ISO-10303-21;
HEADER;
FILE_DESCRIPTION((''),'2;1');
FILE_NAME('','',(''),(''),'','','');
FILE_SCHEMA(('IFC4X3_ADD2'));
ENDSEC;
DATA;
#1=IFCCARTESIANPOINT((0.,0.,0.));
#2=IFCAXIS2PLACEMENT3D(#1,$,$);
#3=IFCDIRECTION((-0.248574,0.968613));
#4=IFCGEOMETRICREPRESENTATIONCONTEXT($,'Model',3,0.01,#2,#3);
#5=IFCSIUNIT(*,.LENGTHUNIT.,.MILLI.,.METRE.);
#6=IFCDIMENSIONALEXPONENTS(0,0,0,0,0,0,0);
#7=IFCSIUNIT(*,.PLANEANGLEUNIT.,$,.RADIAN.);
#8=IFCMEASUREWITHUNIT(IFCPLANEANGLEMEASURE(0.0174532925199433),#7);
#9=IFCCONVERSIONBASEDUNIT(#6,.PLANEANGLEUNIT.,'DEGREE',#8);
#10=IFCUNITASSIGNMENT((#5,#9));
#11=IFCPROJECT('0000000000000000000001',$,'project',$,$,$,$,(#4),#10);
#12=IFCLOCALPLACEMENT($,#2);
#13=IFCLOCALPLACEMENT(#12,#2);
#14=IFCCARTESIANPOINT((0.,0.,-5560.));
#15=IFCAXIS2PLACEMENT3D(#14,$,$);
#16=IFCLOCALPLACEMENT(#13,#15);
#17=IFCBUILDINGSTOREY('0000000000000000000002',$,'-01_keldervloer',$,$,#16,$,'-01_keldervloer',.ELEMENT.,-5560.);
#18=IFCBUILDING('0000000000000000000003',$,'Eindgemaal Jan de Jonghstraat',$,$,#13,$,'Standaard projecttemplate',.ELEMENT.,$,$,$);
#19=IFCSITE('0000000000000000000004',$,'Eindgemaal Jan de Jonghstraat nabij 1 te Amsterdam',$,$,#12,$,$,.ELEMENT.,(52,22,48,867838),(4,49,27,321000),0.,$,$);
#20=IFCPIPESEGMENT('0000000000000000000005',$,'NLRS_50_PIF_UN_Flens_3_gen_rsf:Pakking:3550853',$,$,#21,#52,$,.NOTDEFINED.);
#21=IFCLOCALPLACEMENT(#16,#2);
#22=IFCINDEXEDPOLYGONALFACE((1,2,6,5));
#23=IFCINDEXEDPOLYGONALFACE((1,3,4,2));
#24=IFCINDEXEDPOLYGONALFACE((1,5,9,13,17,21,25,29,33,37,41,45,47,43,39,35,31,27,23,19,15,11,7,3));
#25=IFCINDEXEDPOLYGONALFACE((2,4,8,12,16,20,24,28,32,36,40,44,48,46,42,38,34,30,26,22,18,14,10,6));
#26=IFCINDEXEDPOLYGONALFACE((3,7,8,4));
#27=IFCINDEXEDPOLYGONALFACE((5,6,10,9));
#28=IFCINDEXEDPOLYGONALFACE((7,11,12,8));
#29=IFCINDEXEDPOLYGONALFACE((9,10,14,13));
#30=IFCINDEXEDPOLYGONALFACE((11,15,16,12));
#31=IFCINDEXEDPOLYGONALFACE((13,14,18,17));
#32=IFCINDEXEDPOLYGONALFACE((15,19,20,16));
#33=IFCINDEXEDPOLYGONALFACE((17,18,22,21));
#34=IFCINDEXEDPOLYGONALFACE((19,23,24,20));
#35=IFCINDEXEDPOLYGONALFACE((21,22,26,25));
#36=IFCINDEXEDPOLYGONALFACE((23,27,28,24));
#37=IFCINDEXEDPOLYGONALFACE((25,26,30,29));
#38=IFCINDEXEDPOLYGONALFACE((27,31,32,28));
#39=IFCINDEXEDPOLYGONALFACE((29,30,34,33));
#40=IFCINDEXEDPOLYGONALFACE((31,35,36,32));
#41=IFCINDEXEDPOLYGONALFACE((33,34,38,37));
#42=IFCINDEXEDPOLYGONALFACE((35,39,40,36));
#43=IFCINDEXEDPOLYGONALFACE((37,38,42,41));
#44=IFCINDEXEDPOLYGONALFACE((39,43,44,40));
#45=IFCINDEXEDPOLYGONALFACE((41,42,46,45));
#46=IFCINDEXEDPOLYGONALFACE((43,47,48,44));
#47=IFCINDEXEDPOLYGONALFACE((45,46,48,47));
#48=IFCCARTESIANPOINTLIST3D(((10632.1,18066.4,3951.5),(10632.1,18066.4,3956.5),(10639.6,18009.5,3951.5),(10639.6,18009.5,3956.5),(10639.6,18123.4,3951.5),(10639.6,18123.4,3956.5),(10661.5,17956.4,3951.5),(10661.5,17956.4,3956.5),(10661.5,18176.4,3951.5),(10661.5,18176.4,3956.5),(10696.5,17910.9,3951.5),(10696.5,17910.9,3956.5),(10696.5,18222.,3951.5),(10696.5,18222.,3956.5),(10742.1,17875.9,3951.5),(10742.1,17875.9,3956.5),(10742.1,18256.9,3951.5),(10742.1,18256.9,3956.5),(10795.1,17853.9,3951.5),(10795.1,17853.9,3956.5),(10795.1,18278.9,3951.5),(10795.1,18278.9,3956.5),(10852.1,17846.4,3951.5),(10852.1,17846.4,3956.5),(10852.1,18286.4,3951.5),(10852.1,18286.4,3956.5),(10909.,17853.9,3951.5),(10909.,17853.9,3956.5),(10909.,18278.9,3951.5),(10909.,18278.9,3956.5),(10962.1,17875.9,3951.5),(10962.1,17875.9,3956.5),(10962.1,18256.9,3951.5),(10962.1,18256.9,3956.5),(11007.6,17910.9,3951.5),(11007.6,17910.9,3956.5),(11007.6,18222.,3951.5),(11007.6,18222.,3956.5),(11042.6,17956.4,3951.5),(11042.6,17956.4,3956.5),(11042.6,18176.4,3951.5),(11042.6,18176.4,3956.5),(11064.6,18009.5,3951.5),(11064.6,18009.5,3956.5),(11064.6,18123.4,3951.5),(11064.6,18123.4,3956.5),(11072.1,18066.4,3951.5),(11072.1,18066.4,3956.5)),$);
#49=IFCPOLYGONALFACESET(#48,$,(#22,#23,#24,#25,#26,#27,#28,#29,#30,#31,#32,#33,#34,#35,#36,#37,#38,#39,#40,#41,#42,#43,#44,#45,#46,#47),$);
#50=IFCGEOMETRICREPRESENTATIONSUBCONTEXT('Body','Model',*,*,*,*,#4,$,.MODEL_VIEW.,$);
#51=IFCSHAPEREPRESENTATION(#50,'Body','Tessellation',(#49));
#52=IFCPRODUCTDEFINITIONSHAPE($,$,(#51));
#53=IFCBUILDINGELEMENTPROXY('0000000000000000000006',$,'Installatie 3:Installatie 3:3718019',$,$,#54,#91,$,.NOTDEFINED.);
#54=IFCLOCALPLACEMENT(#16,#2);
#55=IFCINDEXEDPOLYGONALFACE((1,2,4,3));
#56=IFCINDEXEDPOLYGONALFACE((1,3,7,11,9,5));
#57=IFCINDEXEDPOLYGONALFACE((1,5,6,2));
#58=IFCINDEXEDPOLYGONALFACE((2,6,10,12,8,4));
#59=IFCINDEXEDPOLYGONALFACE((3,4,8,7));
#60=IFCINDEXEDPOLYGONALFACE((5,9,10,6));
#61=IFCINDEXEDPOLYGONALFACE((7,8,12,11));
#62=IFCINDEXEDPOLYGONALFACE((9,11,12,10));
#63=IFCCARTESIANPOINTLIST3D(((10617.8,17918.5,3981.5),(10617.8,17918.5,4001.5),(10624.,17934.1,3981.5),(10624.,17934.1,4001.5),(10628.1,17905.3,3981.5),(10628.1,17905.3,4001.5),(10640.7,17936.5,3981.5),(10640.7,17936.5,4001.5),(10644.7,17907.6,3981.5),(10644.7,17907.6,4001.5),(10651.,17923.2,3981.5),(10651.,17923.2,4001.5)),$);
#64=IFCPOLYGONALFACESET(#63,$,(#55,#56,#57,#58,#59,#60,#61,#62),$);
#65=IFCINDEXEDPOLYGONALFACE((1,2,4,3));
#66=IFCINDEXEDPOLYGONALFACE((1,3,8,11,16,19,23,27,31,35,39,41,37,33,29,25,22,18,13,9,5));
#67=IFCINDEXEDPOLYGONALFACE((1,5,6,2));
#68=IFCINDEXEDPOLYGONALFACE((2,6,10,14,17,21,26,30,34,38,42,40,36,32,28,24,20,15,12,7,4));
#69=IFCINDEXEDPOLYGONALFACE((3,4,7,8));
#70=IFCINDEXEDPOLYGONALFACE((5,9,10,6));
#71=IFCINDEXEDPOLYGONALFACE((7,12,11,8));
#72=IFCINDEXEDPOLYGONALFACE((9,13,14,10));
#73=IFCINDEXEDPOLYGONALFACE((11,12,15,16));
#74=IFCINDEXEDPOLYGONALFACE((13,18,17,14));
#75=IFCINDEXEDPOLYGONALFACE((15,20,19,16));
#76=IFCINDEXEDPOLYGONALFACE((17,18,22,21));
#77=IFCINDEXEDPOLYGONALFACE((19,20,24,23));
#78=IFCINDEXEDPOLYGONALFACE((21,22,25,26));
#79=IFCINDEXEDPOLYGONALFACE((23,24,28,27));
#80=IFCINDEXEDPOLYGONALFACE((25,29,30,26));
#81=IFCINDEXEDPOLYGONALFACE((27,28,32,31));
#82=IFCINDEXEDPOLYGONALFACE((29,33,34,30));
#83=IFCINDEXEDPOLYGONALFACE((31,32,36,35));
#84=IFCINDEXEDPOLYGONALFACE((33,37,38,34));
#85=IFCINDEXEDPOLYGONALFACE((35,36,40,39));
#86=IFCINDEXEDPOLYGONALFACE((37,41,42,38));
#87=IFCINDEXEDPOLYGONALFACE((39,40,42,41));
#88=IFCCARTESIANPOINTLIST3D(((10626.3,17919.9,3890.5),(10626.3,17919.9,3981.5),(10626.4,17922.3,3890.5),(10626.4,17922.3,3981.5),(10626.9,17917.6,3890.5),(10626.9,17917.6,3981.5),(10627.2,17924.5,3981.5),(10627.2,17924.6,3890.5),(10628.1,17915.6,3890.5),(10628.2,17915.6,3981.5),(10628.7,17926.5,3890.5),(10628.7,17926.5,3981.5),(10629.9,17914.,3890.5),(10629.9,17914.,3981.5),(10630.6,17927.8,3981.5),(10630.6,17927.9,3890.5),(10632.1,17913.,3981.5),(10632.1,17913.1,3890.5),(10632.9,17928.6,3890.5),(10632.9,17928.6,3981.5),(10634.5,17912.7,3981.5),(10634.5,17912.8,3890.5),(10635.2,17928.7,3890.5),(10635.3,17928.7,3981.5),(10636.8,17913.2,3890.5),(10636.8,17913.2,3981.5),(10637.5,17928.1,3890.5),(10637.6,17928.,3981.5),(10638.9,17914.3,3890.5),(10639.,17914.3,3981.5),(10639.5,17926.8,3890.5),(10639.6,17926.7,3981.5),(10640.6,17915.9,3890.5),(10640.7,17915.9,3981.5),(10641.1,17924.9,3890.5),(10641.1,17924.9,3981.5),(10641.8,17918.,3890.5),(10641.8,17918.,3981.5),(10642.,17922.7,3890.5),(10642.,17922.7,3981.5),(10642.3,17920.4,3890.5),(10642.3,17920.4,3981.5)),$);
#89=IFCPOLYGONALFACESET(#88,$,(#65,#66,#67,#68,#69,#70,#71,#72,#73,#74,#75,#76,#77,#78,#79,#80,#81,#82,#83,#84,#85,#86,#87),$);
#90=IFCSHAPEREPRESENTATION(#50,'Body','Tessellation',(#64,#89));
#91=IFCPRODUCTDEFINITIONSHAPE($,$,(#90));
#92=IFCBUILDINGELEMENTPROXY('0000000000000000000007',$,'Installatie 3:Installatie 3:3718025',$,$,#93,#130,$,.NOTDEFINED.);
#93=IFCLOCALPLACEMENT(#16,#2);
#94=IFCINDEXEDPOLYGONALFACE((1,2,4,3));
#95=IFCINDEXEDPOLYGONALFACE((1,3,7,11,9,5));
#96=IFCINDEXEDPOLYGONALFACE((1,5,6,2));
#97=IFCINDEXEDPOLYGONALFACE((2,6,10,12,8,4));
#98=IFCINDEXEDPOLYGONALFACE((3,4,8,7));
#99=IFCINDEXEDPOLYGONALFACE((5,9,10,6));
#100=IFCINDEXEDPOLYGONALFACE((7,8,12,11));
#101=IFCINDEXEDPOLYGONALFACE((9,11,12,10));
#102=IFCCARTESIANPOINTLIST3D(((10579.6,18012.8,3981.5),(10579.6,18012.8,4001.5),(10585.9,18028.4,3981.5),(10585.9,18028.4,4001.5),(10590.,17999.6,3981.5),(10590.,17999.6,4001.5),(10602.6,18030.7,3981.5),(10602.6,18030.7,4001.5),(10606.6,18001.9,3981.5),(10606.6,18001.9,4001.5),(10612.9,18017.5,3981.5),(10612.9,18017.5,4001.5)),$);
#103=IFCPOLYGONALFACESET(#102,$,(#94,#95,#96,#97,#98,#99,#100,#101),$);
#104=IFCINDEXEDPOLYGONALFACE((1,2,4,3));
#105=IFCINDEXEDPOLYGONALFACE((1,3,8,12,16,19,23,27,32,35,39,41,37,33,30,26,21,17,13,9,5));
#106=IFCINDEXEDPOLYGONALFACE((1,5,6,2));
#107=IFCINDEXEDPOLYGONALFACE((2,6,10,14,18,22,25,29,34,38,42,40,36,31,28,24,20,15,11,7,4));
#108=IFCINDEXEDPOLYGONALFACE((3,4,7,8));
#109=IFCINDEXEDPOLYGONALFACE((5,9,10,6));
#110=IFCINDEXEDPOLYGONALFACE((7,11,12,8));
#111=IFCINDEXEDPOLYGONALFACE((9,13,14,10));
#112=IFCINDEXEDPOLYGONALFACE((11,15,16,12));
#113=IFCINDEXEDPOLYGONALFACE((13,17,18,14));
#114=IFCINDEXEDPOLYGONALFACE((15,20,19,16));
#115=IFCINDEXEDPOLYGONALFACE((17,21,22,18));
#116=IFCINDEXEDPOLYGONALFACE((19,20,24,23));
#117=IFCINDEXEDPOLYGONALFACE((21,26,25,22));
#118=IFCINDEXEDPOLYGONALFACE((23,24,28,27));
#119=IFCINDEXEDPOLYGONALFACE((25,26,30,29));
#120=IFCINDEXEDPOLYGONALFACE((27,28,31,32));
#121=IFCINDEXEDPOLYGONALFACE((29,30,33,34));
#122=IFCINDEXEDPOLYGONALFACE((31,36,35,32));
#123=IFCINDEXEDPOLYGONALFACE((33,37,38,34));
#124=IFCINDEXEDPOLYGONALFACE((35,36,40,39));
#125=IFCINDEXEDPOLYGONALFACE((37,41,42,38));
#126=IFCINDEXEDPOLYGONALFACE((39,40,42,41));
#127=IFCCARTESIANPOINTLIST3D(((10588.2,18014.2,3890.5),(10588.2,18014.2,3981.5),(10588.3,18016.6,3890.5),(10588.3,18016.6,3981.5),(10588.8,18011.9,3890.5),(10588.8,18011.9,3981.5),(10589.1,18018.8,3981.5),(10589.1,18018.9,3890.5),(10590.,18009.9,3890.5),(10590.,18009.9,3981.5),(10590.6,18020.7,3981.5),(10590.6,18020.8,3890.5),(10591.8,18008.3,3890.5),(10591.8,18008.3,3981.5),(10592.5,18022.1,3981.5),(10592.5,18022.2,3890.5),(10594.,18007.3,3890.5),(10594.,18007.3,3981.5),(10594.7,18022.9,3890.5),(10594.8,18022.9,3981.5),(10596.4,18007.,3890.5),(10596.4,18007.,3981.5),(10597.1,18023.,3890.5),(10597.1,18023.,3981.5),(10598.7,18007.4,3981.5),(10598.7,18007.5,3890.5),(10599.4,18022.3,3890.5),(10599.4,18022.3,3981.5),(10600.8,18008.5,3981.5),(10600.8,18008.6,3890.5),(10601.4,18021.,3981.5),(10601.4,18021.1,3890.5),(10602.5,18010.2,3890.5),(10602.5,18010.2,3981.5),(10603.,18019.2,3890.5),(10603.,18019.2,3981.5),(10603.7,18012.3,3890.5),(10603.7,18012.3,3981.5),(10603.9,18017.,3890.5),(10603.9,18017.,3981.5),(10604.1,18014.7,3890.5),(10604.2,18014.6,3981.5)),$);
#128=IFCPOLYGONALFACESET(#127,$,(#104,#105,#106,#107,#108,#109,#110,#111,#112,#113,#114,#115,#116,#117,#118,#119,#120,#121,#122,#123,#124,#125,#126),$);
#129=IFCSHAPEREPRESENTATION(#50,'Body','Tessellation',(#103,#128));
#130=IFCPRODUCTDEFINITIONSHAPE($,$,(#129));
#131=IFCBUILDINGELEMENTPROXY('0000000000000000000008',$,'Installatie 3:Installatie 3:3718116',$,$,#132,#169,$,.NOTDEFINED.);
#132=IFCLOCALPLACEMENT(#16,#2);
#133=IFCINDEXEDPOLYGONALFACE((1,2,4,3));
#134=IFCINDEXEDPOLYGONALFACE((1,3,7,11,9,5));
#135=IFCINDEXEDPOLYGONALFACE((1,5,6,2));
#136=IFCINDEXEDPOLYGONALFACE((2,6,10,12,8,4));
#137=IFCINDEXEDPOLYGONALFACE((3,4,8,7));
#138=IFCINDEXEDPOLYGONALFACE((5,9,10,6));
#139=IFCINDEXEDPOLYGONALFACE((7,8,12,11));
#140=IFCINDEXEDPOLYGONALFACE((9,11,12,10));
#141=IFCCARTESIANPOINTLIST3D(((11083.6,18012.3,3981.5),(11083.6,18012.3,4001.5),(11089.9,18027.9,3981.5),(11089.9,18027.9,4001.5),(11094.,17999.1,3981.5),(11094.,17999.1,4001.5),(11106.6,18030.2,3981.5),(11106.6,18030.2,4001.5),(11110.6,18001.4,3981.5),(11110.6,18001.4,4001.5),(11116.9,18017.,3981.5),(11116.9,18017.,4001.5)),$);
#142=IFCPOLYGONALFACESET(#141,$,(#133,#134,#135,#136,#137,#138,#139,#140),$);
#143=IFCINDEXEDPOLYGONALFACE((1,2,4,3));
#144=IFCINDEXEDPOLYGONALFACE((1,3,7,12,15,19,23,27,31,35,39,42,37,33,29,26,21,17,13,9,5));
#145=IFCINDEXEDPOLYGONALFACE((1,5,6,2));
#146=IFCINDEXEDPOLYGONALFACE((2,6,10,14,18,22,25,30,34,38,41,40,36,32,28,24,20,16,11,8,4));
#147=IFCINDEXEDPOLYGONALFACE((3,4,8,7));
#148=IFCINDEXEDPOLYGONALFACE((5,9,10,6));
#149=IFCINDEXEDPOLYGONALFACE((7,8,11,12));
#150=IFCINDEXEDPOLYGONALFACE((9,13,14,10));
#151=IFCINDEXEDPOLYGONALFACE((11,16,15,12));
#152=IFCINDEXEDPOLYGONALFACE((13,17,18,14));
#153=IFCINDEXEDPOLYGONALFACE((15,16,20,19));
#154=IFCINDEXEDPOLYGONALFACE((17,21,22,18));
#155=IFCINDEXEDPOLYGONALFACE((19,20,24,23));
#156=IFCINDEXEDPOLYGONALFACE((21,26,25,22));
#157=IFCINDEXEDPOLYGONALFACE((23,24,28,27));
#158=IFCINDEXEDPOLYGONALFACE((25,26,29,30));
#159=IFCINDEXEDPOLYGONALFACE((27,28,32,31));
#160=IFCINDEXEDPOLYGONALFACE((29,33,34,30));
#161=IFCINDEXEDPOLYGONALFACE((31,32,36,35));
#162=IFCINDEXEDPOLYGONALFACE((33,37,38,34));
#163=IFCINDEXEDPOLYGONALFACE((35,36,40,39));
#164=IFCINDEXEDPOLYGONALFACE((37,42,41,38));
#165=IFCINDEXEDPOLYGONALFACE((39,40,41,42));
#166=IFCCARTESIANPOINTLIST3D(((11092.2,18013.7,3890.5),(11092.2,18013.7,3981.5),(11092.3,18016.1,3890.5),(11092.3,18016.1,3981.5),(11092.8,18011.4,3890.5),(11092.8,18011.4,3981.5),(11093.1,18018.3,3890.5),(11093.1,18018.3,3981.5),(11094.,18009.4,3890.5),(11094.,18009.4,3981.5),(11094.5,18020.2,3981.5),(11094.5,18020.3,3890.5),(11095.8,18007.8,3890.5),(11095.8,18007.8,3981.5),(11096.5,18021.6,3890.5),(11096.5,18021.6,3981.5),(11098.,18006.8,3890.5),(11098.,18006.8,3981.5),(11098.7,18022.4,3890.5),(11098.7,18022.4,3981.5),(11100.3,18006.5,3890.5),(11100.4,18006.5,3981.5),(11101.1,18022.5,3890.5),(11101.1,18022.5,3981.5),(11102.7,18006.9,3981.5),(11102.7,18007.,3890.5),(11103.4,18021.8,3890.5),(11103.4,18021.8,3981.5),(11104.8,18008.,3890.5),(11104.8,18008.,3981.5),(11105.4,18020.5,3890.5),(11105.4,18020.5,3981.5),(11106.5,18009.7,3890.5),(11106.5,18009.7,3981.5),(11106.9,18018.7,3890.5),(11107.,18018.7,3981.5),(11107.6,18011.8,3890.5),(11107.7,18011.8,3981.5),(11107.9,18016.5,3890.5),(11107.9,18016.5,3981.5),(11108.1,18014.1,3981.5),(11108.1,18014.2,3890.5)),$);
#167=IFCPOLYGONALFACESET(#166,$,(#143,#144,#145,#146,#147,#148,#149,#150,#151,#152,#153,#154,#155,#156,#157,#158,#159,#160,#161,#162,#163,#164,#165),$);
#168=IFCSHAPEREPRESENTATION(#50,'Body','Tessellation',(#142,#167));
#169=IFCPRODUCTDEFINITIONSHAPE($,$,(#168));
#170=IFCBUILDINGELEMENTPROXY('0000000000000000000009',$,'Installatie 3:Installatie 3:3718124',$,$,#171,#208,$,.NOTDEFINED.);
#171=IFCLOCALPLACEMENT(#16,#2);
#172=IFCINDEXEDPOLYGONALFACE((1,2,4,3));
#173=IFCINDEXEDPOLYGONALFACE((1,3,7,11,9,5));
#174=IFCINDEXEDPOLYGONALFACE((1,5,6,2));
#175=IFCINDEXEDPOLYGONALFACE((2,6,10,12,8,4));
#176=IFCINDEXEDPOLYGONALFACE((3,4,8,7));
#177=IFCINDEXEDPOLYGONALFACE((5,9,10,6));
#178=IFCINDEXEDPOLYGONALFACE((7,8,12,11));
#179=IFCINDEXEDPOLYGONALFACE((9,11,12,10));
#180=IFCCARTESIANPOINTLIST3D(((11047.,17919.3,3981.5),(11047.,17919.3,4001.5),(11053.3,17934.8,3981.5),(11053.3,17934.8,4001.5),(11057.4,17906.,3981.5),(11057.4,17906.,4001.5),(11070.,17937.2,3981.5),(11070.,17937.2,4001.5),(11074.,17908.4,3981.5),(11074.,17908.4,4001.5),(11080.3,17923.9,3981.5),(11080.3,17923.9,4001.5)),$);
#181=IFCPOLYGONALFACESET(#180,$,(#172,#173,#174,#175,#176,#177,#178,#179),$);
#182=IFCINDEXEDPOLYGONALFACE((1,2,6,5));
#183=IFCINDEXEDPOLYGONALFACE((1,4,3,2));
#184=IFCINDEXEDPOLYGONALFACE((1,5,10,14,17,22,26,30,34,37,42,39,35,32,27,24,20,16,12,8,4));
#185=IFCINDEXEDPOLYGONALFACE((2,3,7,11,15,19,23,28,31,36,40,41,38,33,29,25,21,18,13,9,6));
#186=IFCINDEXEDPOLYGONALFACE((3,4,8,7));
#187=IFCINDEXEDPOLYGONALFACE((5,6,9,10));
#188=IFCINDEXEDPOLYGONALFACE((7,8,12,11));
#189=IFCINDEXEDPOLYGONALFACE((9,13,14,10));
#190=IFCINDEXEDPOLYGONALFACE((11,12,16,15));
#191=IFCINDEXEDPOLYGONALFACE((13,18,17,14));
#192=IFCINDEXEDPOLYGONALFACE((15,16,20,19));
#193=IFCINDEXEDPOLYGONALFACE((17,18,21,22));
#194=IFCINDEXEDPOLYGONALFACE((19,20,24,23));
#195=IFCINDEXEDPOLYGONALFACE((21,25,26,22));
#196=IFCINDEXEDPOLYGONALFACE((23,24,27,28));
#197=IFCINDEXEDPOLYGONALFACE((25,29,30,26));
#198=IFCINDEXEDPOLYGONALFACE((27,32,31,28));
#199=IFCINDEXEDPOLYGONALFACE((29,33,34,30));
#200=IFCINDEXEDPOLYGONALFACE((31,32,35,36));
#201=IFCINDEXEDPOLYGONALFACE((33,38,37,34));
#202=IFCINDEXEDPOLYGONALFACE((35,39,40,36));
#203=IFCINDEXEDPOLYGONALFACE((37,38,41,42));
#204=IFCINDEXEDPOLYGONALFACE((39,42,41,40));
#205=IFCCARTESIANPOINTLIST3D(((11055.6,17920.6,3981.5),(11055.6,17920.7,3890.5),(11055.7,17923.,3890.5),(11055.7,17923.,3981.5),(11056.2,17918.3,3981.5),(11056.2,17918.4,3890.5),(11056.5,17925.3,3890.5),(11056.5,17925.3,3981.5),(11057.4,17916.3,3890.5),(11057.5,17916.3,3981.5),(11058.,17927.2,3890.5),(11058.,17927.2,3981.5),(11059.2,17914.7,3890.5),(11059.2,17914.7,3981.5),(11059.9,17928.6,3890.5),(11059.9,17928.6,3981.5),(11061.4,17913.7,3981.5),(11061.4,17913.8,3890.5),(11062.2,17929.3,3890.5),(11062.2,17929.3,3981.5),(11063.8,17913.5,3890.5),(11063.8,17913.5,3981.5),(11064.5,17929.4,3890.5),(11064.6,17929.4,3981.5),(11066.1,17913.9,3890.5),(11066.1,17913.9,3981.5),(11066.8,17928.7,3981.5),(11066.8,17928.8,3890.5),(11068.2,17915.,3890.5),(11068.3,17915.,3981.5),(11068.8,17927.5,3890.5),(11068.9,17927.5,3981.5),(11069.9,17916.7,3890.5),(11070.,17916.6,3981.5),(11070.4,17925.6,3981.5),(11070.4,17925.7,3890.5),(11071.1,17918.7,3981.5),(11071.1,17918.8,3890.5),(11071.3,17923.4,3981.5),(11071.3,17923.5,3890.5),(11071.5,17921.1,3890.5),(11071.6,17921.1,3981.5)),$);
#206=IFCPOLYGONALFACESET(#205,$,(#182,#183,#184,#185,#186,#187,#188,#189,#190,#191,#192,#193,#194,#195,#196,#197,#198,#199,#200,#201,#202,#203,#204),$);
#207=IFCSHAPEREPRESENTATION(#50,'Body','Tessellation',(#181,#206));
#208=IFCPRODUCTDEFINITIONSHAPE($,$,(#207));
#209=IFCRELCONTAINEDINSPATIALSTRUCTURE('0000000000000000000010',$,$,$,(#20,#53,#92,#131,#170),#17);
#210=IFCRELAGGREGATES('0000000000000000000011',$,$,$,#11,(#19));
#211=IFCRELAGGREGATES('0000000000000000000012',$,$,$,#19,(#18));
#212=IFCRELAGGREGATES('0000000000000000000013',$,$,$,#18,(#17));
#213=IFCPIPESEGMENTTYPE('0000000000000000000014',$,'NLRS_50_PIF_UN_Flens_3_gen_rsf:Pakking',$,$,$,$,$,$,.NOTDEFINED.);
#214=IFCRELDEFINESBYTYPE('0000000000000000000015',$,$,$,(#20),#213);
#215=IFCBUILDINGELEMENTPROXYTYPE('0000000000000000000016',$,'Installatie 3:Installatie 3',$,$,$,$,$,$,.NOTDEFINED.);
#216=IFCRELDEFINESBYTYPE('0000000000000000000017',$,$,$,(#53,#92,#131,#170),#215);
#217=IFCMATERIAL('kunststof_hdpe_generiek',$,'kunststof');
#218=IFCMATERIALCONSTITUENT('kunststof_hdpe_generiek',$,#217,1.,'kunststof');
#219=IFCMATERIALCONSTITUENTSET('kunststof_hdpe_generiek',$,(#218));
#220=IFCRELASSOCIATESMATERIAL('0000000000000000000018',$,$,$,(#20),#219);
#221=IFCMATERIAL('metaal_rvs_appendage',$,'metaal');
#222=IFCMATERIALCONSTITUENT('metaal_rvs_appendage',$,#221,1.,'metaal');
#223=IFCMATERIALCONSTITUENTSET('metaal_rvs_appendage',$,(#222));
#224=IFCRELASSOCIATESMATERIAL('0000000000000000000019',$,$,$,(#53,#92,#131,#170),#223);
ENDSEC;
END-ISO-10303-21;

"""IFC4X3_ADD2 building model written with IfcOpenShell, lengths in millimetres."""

from ifc_helpers import new_model, entity, si_unit, converted_unit, direction, frame, frame_2d, origin, place, context, subcontext, project, spatial, polyline, circle, outline, extrude, source, transform, mapped, material, constituent, constituent_set, type_object, type_shapes, element, save


model = new_model("IFC4X3_ADD2")

# Units and contexts
model_context = context("Model", 3, precision=0.01, world=origin(), true_north=direction((-0.248574, 0.968613)))
body_context = subcontext(model_context, "Body", "Model", "MODEL_VIEW")
ifc_project = project(units=[si_unit("LENGTHUNIT", "METRE", prefix="MILLI"), converted_unit("PLANEANGLEUNIT", "DEGREE", entity("IfcPlaneAngleMeasure", 0.0174532925199433), si_unit("PLANEANGLEUNIT", "RADIAN"), dimensions=[0, 0, 0, 0, 0, 0, 0])], contexts=[model_context])

# Site, building, storey
site_placement = place(None, origin())
site = spatial("IfcSite", under=ifc_project, at=site_placement, Name="Eindgemaal Jan de Jonghstraat nabij 1 te Amsterdam", CompositionType="ELEMENT", RefLatitude=(52, 22, 48, 867838), RefLongitude=(4, 49, 27, 321000), RefElevation=0.0)
building_placement = place(site_placement, origin())
building = spatial("IfcBuilding", under=site, at=building_placement, Name="Eindgemaal Jan de Jonghstraat", LongName="Standaard projecttemplate", CompositionType="ELEMENT")
storey_placement = place(building_placement, frame((0.0, 0.0, -5560.0)))
storey = spatial("IfcBuildingStorey", under=building, at=storey_placement, Name="-01_keldervloer", LongName="-01_keldervloer", CompositionType="ELEMENT", Elevation=-5560.0)

# Pipe segment
ifc_material_1 = material(Name="kunststof_hdpe_generiek", Category="kunststof")
ifc_constituent_1 = constituent(ifc_material_1, Name="kunststof_hdpe_generiek", Category="kunststof", fraction=1.0)
ifc_constituent_set_1 = constituent_set(constituents=[ifc_constituent_1], Name="kunststof_hdpe_generiek")
pipe_segment_type_1 = type_object("IfcPipeSegmentType", Name="NLRS_50_PIF_UN_Flens_3_gen_rsf:Pakking", PredefinedType="NOTDEFINED")
shared_shape_1 = source(origin(), body_context, "Body", "SweptSolid", [
    extrude(circle(Radius=220.0, at=frame_2d((0.0, 0.0), x_axis=(1.0, 0.0))), frame((0.0, 0.0, 0.0), z_axis=(0.0, 0.0, 1.0), x_axis=(0.0, -1.0, 0.0)), (0.0, 0.0, 1.0), 5.0),
])
type_shapes(pipe_segment_type_1, [shared_shape_1])
pipe_segment_1_placement = place(storey_placement, frame((10852.1, 18066.4, 3956.5), z_axis=(0.0, 0.0, -1.0), x_axis=(1.0, 0.0, 0.0)))
element("IfcPipeSegment", 1, at=pipe_segment_1_placement, inside=storey, type_object=pipe_segment_type_1, material=ifc_constituent_set_1, Name="NLRS_50_PIF_UN_Flens_3_gen_rsf:Pakking:3550853", PredefinedType="NOTDEFINED", context=body_context, shape_type="MappedRepresentation", body=[
    mapped(shared_shape_1, transform((0.0, 0.0, 0.0), scale=1.0)),
])

# Building element proxies
ifc_material_2 = material(Name="metaal_rvs_appendage", Category="metaal")
ifc_constituent_2 = constituent(ifc_material_2, Name="metaal_rvs_appendage", Category="metaal", fraction=1.0)
ifc_constituent_set_2 = constituent_set(constituents=[ifc_constituent_2], Name="metaal_rvs_appendage")
building_element_proxy_type_1 = type_object("IfcBuildingElementProxyType", Name="Installatie 3:Installatie 3", PredefinedType="NOTDEFINED")
shared_shape_2 = source(origin(), body_context, "Body", "SweptSolid", [
    extrude(outline(polyline([(-8.4, -14.6), (8.4, -14.6), (16.8, 0.0), (8.4, 14.6), (-8.4, 14.6), (-16.8, 0.0), (-8.4, -14.6)])), frame((0.0, 0.0, 41.5), z_axis=(0.0, 0.0, 1.0), x_axis=(-0.400458, 0.916315, 0.0)), (0.0, 0.0, 1.0), 20.0),
    extrude(circle(Radius=8.0, at=frame_2d((0.0, 0.0), x_axis=(1.0, 0.0))), frame((-0.2, -0.1, -49.5), z_axis=(0.000101, -0.000286, 1.0), x_axis=(1.0, 0.0, -0.000101)), (0.0, 0.0, 1.0), 91.1),
])
type_shapes(building_element_proxy_type_1, [shared_shape_2])
for number, where, z_axis, x_axis, name in (
    (2, (10634.4, 17920.9, 3940.0), (0.0, 0.0, 1.0), (0.968613, 0.248574, 0.0), "Installatie 3:Installatie 3:3718019"),
    (3, (10596.3, 18015.2, 3940.0), (0.0, 0.0, 1.0), (0.968613, 0.248574, 0.0), "Installatie 3:Installatie 3:3718025"),
    (4, (11100.3, 18014.7, 3940.0), (0.0, 0.0, 1.0), (0.968613, 0.248574, 0.0), "Installatie 3:Installatie 3:3718116"),
    (5, (11063.7, 17921.6, 3940.0), (0.0, 0.0, 1.0), (0.968613, 0.248574, 0.0), "Installatie 3:Installatie 3:3718124"),
):
    element("IfcBuildingElementProxy", number, at=place(storey_placement, frame(where, z_axis=z_axis, x_axis=x_axis)), inside=storey, type_object=building_element_proxy_type_1, material=ifc_constituent_set_2, Name=name, PredefinedType="NOTDEFINED", context=body_context, shape_type="MappedRepresentation", body=[
        mapped(shared_shape_2, transform((0.0, 0.0, 0.0), scale=1.0)),
    ])

save(model, "model.ifc")
